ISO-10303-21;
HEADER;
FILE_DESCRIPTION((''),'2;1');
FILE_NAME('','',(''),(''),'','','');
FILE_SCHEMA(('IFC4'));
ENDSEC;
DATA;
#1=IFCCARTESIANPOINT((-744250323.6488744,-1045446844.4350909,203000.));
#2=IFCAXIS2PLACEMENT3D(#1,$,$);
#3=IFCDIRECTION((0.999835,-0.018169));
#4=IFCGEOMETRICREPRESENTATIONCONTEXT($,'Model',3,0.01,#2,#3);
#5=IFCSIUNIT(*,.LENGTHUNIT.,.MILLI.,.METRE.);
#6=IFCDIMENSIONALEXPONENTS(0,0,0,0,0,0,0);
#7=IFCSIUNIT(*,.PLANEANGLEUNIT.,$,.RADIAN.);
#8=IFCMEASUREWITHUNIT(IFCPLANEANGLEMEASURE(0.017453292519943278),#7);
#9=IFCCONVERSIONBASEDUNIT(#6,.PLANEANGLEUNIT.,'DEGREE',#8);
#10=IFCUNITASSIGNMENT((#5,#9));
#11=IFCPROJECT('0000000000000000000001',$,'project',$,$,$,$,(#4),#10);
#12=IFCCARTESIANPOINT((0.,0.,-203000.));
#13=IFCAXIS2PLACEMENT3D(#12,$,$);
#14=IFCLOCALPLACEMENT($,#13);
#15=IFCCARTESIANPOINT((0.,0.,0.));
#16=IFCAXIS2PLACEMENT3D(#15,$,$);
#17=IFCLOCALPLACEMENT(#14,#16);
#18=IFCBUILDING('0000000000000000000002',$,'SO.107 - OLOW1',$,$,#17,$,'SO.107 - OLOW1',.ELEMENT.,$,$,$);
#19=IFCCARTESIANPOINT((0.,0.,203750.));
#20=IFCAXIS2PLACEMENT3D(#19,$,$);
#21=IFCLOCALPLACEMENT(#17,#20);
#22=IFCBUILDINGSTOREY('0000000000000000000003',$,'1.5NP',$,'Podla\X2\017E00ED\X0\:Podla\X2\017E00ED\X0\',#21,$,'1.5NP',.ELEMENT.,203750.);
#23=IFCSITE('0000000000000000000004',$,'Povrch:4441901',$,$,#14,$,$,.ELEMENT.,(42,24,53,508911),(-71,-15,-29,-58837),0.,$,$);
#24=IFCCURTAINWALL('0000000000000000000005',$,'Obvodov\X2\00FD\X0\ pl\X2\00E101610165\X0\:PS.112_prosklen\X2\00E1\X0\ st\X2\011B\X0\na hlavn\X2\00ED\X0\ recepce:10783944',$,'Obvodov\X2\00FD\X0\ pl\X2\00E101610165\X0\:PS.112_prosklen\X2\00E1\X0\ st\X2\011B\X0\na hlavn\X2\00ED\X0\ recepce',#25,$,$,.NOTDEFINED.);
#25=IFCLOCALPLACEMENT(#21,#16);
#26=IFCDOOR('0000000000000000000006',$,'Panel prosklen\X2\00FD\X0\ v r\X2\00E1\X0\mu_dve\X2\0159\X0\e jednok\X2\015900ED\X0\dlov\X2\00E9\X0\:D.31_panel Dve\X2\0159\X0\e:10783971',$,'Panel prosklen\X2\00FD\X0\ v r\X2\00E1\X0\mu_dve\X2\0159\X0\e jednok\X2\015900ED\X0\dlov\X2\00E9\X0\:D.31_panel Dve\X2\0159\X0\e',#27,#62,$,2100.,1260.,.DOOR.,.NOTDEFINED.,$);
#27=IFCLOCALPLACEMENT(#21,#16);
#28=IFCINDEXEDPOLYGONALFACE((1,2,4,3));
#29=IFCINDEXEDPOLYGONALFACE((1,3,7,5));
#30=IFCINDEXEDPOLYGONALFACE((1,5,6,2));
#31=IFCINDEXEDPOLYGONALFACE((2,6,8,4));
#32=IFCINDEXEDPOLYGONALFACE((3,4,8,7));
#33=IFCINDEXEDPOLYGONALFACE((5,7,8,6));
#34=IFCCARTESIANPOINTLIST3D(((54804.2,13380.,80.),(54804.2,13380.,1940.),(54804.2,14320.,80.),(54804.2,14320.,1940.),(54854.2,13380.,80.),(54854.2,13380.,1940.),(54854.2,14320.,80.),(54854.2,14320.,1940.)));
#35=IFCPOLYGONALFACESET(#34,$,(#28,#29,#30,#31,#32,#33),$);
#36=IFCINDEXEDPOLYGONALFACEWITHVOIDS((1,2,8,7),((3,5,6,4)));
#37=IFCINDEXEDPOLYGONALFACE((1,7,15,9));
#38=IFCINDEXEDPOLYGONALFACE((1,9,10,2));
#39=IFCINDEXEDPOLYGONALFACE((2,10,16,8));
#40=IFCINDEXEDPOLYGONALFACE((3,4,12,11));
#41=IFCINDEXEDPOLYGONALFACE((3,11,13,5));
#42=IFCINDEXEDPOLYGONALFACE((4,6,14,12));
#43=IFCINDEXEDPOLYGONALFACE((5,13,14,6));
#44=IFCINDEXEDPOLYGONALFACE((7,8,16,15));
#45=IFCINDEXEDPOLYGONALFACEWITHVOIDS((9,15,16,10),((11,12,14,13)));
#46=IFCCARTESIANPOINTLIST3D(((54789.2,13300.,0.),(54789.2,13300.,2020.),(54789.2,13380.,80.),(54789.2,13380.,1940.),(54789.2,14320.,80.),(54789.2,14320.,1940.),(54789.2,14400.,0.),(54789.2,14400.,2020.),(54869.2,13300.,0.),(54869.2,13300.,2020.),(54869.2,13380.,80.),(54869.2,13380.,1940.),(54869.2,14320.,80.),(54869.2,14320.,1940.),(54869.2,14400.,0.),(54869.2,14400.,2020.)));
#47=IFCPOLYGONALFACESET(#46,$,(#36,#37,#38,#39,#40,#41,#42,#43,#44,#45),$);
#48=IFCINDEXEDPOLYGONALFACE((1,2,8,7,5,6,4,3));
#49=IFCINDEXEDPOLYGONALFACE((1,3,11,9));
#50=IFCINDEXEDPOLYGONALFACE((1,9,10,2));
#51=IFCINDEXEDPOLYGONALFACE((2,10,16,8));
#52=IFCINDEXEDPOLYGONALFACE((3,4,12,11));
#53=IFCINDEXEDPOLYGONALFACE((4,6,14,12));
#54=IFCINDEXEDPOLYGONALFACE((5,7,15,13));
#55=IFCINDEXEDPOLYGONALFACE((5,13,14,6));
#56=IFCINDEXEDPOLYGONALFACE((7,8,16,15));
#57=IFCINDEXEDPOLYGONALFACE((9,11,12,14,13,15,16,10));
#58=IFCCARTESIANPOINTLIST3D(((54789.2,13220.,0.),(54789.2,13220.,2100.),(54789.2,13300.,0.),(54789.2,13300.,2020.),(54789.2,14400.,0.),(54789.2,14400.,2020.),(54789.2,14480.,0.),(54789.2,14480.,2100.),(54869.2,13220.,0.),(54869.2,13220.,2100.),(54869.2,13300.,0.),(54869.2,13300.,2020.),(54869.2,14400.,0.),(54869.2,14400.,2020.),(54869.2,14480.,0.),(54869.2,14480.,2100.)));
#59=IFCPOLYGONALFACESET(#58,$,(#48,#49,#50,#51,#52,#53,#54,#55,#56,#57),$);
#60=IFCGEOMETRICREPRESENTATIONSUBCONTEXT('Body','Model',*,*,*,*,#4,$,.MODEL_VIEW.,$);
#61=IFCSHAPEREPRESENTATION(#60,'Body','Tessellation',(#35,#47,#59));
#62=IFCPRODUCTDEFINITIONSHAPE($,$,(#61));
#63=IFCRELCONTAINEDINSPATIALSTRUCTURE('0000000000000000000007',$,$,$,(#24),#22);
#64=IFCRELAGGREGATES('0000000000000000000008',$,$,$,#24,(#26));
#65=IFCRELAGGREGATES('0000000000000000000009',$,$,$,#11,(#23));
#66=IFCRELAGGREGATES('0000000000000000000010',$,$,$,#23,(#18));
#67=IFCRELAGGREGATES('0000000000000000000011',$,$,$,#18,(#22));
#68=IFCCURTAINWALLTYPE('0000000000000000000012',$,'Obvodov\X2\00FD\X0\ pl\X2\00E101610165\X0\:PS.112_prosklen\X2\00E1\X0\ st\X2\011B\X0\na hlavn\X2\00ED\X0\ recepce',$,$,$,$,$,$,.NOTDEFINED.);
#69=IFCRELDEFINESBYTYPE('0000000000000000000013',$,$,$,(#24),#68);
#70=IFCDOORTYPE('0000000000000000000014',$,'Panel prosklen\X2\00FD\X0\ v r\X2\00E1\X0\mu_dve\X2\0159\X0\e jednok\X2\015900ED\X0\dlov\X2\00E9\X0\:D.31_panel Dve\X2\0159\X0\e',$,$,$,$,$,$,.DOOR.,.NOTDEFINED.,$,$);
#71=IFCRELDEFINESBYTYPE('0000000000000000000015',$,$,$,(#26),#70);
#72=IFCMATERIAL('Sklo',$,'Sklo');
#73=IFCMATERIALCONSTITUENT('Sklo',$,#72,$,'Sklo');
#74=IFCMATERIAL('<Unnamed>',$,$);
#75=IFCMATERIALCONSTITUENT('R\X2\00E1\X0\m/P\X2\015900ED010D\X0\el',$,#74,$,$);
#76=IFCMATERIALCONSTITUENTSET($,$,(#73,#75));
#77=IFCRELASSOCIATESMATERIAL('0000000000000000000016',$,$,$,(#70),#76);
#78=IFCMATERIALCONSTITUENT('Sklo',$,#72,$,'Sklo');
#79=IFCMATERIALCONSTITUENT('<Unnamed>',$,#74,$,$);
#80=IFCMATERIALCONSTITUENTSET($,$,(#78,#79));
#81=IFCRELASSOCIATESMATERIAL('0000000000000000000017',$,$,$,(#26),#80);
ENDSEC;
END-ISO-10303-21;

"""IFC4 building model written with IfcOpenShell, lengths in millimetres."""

from ifc_helpers import new_model, entity, si_unit, converted_unit, direction, frame, origin, place, context, subcontext, project, spatial, indexed_curve, outline, extrude, source, transform, mapped, material, constituent, constituent_set, type_object, type_shapes, element, aggregate, save


model = new_model("IFC4")

# Units and contexts
model_context = context("Model", 3, precision=0.01, world=frame((-744250323.6488744, -1045446844.4350909, 203000.0)), true_north=direction((0.999835, -0.018169)))
body_context = subcontext(model_context, "Body", "Model", "MODEL_VIEW")
ifc_project = project(units=[si_unit("LENGTHUNIT", "METRE", prefix="MILLI"), converted_unit("PLANEANGLEUNIT", "DEGREE", entity("IfcPlaneAngleMeasure", 0.017453292519943278), si_unit("PLANEANGLEUNIT", "RADIAN"), dimensions=[0, 0, 0, 0, 0, 0, 0])], contexts=[model_context])

# Site, building, storey
site_placement = place(None, frame((0.0, 0.0, -203000.0)))
site = spatial("IfcSite", under=ifc_project, at=site_placement, Name="Povrch:4441901", CompositionType="ELEMENT", RefLatitude=(42, 24, 53, 508911), RefLongitude=(-71, -15, -29, -58837), RefElevation=0.0)
building_placement = place(site_placement, origin())
building = spatial("IfcBuilding", under=site, at=building_placement, Name="SO.107 - OLOW1", LongName="SO.107 - OLOW1", CompositionType="ELEMENT")
storey_placement = place(building_placement, frame((0.0, 0.0, 203750.0)))
storey = spatial("IfcBuildingStorey", under=building, at=storey_placement, Name="1.5NP", ObjectType="Podlaží:Podlaží", LongName="1.5NP", CompositionType="ELEMENT", Elevation=203750.0)

# Curtain wall
curtain_wall_type_1 = type_object("IfcCurtainWallType", Name="Obvodový plášť:PS.112_prosklená stěna hlavní recepce", PredefinedType="NOTDEFINED")
curtain_wall_1_placement = place(storey_placement, frame((0.0, 0.0, -203750.0)))
curtain_wall_1 = element("IfcCurtainWall", 1, at=curtain_wall_1_placement, inside=storey, type_object=curtain_wall_type_1, Name="Obvodový plášť:PS.112_prosklená stěna hlavní recepce:10783944", ObjectType="Obvodový plášť:PS.112_prosklená stěna hlavní recepce", PredefinedType="NOTDEFINED")
ifc_material_1 = material(Name="<Unnamed>")

# Shared definitions
ifc_material_2 = material(Name="Sklo", Category="Sklo")

# Door
ifc_constituent_1 = constituent(ifc_material_2, Name="Sklo", Category="Sklo")
ifc_constituent_2 = constituent(ifc_material_1, Name="<Unnamed>")
ifc_constituent_set_1 = constituent_set(constituents=[ifc_constituent_1, ifc_constituent_2])
ifc_constituent_3 = constituent(ifc_material_2, Name="Sklo", Category="Sklo")
ifc_constituent_4 = constituent(ifc_material_1, Name="Rám/Příčel")
ifc_constituent_set_2 = constituent_set(constituents=[ifc_constituent_3, ifc_constituent_4])
door_type_1 = type_object("IfcDoorType", Name="Panel prosklený v rámu_dveře jednokřídlové:D.31_panel Dveře", OperationType="NOTDEFINED", PredefinedType="DOOR", material=ifc_constituent_set_2)
shared_shape_1 = source(origin(), body_context, "Body", "SweptSolid", [
    extrude(outline(indexed_curve([(-470.0, -25.0), (470.0, -25.0), (470.0, 25.0), (-470.0, 25.0), (-470.0, -25.0)], self_intersect=False)), frame((0.0, 0.0, 80.0), z_axis=(0.0, 0.0, 1.0), x_axis=(-1.0, 0.0, 0.0)), (0.0, 0.0, 1.0), 1860.0),
    extrude(outline(indexed_curve([(-1010.0, -550.0), (1010.0, -550.0), (1010.0, 550.0), (-1010.0, 550.0), (-1010.0, -550.0)], self_intersect=False), holes=[indexed_curve([(-930.0, -470.0), (-930.0, 470.0), (930.0, 470.0), (930.0, -470.0), (-930.0, -470.0)], self_intersect=False)]), frame((0.0, -40.0, 1010.0), z_axis=(0.0, 1.0, 0.0), x_axis=(0.0, 0.0, -1.0)), (0.0, 0.0, 1.0), 80.0),
    extrude(outline(indexed_curve([(-1070.0, -630.0), (1030.0, -630.0), (1030.0, -550.0), (-990.0, -550.0), (-990.0, 550.0), (1030.0, 550.0), (1030.0, 630.0), (-1070.0, 630.0), (-1070.0, -630.0)], self_intersect=False)), frame((0.0, -40.0, 1030.0), z_axis=(0.0, 1.0, 0.0), x_axis=(0.0, 0.0, -1.0)), (0.0, 0.0, 1.0), 80.0),
])
type_shapes(door_type_1, [shared_shape_1])
door_1_placement = place(curtain_wall_1_placement, frame((54829.2, 13850.0, 203750.0), z_axis=(0.0, 0.0, 1.0), x_axis=(0.0, 1.0, 0.0)))
door_1 = element("IfcDoor", 2, at=door_1_placement, type_object=door_type_1, material=ifc_constituent_set_1, Name="Panel prosklený v rámu_dveře jednokřídlové:D.31_panel Dveře:10783971", ObjectType="Panel prosklený v rámu_dveře jednokřídlové:D.31_panel Dveře", OperationType="NOTDEFINED", OverallHeight=2100.0, OverallWidth=1260.0, PredefinedType="DOOR", context=body_context, shape_type="MappedRepresentation", body=[
    mapped(shared_shape_1, transform((0.0, 0.0, 0.0), scale=1.0)),
])
aggregate(curtain_wall_1, [door_1])

save(model, "model.ifc")
